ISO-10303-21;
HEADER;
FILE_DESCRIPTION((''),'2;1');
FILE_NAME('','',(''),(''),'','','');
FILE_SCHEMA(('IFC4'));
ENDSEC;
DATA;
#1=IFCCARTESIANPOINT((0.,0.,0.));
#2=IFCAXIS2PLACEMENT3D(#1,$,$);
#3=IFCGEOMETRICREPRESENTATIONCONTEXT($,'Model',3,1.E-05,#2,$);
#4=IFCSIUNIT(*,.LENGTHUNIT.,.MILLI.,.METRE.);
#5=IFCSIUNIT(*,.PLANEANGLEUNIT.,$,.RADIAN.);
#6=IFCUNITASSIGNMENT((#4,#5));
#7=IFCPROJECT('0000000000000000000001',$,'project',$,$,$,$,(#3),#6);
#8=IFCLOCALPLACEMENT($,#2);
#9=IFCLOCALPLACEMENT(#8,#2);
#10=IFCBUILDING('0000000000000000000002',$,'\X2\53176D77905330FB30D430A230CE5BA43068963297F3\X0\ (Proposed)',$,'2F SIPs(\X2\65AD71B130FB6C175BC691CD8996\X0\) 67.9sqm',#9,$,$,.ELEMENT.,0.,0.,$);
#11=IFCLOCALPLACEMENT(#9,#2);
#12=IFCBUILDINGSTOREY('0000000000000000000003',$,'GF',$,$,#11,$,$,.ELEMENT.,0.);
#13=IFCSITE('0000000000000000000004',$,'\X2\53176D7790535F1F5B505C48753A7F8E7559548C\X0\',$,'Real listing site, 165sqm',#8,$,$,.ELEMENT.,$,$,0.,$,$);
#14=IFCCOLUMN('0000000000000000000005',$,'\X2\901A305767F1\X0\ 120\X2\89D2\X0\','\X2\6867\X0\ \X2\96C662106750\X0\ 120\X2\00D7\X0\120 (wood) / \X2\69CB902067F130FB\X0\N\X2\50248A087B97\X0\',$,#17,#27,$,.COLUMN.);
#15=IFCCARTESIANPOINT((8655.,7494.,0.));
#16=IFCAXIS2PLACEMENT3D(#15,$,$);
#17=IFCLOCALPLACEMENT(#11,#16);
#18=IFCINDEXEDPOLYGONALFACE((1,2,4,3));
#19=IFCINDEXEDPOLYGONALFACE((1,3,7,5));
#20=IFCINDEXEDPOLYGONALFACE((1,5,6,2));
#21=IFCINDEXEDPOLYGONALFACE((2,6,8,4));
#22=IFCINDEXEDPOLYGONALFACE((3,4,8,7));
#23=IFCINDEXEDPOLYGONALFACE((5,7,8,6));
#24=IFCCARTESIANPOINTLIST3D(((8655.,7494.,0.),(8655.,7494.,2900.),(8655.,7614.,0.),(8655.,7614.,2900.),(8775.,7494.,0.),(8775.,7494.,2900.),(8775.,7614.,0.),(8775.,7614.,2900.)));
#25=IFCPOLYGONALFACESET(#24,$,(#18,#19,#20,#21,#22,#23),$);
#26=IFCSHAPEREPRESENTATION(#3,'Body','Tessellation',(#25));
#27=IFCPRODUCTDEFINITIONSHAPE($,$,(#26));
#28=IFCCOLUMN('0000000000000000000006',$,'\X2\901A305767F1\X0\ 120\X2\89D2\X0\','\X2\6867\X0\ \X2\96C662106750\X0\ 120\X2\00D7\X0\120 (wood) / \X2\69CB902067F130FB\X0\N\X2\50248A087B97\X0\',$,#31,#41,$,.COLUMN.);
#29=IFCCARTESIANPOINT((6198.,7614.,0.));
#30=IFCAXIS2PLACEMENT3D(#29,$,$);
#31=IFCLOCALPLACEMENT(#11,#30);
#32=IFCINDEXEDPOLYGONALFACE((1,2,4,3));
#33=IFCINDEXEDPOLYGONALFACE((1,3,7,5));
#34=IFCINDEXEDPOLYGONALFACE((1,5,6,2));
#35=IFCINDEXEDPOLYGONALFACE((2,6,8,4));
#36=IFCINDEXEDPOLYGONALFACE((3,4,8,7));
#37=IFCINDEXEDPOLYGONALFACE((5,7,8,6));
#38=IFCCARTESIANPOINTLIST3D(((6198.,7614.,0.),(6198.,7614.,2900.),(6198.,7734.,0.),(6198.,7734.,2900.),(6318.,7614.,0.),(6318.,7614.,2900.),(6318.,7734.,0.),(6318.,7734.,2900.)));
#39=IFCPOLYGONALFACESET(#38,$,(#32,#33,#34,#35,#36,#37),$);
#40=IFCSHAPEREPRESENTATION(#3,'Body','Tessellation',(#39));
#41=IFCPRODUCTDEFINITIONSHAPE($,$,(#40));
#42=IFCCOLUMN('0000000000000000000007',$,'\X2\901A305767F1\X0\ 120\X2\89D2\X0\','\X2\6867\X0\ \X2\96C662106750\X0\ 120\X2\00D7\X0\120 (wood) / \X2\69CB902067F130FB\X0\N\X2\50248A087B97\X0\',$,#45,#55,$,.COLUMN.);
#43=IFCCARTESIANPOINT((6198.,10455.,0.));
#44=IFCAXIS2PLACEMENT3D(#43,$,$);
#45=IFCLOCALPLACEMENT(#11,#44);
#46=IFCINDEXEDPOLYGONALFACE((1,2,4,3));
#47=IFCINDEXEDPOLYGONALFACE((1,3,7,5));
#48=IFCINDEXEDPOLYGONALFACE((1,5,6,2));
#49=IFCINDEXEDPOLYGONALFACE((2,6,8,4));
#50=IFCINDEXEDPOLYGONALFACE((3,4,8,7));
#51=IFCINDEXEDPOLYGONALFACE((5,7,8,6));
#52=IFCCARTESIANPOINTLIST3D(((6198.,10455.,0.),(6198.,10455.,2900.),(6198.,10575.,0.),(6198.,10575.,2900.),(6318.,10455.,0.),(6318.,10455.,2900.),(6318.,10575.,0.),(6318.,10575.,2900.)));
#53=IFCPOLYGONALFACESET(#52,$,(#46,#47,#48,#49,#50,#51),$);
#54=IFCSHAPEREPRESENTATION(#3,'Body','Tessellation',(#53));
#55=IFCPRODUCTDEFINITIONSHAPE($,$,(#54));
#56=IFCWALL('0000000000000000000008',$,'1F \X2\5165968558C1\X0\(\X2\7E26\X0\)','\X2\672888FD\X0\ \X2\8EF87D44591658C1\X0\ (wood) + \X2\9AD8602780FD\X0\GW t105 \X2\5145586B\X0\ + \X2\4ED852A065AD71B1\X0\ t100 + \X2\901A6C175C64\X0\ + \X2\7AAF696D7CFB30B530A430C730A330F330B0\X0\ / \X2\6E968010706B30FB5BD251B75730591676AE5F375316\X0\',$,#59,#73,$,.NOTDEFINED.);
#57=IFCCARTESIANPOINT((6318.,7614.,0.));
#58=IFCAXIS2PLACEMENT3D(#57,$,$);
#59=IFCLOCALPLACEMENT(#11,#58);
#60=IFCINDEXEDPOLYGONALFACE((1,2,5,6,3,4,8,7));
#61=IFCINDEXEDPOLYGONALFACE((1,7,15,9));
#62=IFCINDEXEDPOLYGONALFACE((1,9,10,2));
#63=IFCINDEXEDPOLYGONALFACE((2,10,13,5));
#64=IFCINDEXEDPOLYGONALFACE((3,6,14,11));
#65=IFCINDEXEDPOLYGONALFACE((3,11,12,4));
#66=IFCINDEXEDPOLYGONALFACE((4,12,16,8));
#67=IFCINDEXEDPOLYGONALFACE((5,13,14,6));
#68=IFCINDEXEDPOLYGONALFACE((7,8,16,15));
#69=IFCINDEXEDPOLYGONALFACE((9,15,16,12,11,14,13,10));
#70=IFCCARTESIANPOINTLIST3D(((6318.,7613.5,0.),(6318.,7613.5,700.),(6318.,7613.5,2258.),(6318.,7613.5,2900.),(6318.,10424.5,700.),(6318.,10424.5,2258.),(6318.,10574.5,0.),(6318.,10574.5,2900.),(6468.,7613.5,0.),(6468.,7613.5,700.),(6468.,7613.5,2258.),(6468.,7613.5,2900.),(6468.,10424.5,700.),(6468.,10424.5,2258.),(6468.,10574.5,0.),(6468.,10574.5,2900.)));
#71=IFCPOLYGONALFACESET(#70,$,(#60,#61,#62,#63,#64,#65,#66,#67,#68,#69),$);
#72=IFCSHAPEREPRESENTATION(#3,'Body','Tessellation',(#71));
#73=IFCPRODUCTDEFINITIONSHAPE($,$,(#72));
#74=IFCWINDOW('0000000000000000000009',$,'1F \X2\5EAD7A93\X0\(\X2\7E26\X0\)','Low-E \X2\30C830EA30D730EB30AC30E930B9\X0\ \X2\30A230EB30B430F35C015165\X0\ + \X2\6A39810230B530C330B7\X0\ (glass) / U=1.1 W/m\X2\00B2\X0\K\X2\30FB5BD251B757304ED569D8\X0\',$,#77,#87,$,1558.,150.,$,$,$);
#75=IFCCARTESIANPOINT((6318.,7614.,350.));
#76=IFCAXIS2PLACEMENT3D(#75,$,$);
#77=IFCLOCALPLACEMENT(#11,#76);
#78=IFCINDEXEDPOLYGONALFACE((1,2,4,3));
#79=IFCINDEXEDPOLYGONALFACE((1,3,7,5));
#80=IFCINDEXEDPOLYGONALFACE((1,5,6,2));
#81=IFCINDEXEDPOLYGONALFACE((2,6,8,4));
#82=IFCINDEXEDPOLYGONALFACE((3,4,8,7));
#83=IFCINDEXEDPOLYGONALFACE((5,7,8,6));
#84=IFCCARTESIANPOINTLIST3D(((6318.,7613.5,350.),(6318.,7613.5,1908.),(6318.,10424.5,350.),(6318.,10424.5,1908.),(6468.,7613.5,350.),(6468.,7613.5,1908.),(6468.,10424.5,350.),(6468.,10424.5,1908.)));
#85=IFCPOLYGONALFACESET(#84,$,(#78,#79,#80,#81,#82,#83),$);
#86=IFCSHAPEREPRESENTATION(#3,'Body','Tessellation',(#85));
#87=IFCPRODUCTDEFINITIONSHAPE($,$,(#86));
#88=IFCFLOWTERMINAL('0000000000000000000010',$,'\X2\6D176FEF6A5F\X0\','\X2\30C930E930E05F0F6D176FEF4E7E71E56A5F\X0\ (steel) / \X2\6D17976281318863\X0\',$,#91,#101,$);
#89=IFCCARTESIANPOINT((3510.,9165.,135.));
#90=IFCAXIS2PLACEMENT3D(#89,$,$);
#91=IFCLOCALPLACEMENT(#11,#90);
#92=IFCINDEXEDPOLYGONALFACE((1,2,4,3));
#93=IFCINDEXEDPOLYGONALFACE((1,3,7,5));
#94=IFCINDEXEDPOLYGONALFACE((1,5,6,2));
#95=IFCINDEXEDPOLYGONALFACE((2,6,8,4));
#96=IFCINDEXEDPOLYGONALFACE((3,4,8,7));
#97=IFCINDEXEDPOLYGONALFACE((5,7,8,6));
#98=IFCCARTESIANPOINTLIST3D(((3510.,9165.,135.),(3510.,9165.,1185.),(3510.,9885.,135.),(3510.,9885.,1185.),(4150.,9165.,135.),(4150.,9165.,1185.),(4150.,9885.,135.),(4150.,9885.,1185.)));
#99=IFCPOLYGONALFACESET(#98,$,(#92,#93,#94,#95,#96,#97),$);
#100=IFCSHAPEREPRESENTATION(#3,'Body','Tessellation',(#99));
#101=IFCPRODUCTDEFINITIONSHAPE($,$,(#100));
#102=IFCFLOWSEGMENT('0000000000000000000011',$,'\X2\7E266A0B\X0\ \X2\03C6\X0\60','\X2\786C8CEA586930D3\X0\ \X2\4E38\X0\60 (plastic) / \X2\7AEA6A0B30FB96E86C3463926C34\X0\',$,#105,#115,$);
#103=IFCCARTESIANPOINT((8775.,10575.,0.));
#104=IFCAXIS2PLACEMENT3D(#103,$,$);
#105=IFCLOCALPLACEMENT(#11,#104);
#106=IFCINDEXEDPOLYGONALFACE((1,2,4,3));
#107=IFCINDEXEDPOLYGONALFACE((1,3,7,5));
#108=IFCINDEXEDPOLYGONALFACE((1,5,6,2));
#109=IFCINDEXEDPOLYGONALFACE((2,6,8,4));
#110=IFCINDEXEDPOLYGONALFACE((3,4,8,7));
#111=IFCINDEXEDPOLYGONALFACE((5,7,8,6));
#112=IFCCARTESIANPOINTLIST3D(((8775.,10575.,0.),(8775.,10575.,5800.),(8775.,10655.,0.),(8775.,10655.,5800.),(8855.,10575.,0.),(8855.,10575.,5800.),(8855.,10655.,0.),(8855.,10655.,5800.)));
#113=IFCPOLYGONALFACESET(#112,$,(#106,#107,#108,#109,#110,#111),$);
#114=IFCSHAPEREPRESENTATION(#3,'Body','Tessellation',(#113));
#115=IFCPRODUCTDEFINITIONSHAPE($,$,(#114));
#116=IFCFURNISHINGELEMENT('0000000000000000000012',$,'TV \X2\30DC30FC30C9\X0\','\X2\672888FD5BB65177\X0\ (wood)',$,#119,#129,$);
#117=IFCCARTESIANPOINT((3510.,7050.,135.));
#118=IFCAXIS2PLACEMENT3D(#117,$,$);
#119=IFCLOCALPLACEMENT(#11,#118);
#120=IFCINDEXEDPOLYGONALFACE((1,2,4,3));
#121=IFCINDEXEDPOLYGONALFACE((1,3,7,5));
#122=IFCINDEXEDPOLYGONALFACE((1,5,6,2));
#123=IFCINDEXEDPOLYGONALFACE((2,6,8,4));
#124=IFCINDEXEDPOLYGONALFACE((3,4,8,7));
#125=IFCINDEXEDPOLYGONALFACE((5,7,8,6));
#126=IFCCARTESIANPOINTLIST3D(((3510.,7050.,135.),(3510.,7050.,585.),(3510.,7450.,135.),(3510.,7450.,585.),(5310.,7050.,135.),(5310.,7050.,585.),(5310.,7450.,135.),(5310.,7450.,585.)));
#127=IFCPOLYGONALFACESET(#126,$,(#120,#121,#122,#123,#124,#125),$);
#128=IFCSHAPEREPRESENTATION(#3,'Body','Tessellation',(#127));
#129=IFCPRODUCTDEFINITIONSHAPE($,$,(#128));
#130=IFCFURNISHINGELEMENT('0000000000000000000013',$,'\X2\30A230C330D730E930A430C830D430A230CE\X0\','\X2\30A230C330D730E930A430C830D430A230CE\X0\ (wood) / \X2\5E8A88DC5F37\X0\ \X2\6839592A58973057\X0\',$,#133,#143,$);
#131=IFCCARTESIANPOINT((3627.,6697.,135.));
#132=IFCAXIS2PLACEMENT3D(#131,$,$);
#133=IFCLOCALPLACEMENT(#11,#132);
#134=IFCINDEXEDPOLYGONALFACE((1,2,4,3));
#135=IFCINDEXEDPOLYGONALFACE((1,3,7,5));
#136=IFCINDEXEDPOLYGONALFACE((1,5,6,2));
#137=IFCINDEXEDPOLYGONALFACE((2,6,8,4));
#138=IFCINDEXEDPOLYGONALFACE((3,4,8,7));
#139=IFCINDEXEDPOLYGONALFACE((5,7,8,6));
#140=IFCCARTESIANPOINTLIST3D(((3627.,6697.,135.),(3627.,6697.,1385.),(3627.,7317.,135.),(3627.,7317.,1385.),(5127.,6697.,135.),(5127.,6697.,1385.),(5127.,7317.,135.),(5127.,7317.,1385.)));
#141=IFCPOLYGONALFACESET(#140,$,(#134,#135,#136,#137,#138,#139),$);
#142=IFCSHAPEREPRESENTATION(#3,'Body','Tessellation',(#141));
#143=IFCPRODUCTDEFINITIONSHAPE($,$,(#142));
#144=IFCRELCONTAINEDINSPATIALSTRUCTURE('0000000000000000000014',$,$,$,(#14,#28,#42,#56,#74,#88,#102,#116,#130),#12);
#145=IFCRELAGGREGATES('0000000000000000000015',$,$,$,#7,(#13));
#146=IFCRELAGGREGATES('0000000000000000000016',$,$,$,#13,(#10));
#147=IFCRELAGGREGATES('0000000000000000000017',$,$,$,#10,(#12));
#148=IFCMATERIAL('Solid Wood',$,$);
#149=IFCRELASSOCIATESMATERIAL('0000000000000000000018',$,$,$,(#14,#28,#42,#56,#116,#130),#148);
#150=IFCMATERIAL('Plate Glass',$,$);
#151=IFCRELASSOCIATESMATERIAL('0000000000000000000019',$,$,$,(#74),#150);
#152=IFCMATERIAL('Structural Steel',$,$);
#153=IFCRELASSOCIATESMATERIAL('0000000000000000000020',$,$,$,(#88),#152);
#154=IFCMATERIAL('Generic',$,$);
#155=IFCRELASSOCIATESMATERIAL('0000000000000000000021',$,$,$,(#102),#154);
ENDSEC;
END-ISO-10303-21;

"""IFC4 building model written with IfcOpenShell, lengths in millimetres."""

from ifc_helpers import new_model, si_unit, frame, frame_2d, origin, place, context, project, spatial, rectangle, extrude, material, element, fill, save


model = new_model("IFC4")

# Units and contexts
model_context = context("Model", 3, precision=1e-05, world=origin())
ifc_project = project(units=[si_unit("LENGTHUNIT", "METRE", prefix="MILLI"), si_unit("PLANEANGLEUNIT", "RADIAN")], contexts=[model_context])

# Site, building, storey
site_placement = place(None, origin())
site = spatial("IfcSite", under=ifc_project, at=site_placement, Name="北海道弟子屈町美留和", ObjectType="Real listing site, 165sqm", CompositionType="ELEMENT", RefElevation=0.0)
building_placement = place(site_placement, origin())
building = spatial("IfcBuilding", under=site, at=building_placement, Name="北海道・ピアノ室と防音 (Proposed)", ObjectType="2F SIPs(断熱・気密重視) 67.9sqm", CompositionType="ELEMENT", ElevationOfRefHeight=0.0, ElevationOfTerrain=0.0)
storey_placement = place(building_placement, origin())
storey = spatial("IfcBuildingStorey", under=building, at=storey_placement, Name="GF", CompositionType="ELEMENT", Elevation=0.0)

# Columns
ifc_material_1 = material(Name="Solid Wood")
column_1_placement = place(storey_placement, frame((8655.0, 7494.0, 0.0)))
element("IfcColumn", 1, at=column_1_placement, inside=storey, material=ifc_material_1, Name="通し柱 120角", Description="桧 集成材 120×120 (wood) / 構造柱・N値計算", PredefinedType="COLUMN", context=model_context, shape_type="SweptSolid", body=[
    extrude(rectangle(XDim=120.0, YDim=120.0, at=frame_2d((60.0, 60.0))), frame((8655.0, 7494.0, 0.0)), (0.0, 0.0, 1.0), 2900.0),
])
column_2_placement = place(storey_placement, frame((6198.0, 7614.0, 0.0)))
element("IfcColumn", 2, at=column_2_placement, inside=storey, material=ifc_material_1, Name="通し柱 120角", Description="桧 集成材 120×120 (wood) / 構造柱・N値計算", PredefinedType="COLUMN", context=model_context, shape_type="SweptSolid", body=[
    extrude(rectangle(XDim=120.0, YDim=120.0, at=frame_2d((60.0, 60.0))), frame((6198.0, 7614.0, 0.0)), (0.0, 0.0, 1.0), 2900.0),
])
column_3_placement = place(storey_placement, frame((6198.0, 10455.0, 0.0)))
element("IfcColumn", 3, at=column_3_placement, inside=storey, material=ifc_material_1, Name="通し柱 120角", Description="桧 集成材 120×120 (wood) / 構造柱・N値計算", PredefinedType="COLUMN", context=model_context, shape_type="SweptSolid", body=[
    extrude(rectangle(XDim=120.0, YDim=120.0, at=frame_2d((60.0, 60.0))), frame((6198.0, 10455.0, 0.0)), (0.0, 0.0, 1.0), 2900.0),
])

# Wall, opening, window
wall_1_placement = place(storey_placement, frame((6318.0, 7614.0, 0.0)))
wall_1 = element("IfcWall", 4, at=wall_1_placement, inside=storey, material=ifc_material_1, Name="1F 入隅壁(縦)", Description="木製 軸組外壁 (wood) + 高性能GW t105 充填 + 付加断熱 t100 + 通気層 + 窯業系サイディング / 準耐火・寒冷地外皮強化", PredefinedType="NOTDEFINED", context=model_context, shape_type="SweptSolid", body=[
    extrude(rectangle(XDim=150.0, YDim=2961.0, at=frame_2d((75.0, 1480.0))), frame((6318.0, 7614.0, 0.0)), (0.0, 0.0, 1.0), 2900.0),
])
opening_placement = place(storey_placement, frame((6318.0, 7614.0, 350.0)))
opening = element("IfcOpeningElement", 5, at=opening_placement, cuts=wall_1, PredefinedType="NOTDEFINED", context=model_context, shape_type="SweptSolid", body=[
    extrude(rectangle(XDim=150.0, YDim=2811.0, at=frame_2d((75.0, 1405.0))), frame((6318.0, 7614.0, 350.0)), (0.0, 0.0, 1.0), 1558.0),
])
ifc_material_2 = material(Name="Plate Glass")
window_placement = place(storey_placement, frame((6318.0, 7614.0, 350.0)))
window = element("IfcWindow", 6, at=window_placement, inside=storey, material=ifc_material_2, Name="1F 庭窓(縦)", Description="Low-E トリプルガラス アルゴン封入 + 樹脂サッシ (glass) / U=1.1 W/m²K・寒冷地仕様", OverallHeight=1558.0, OverallWidth=150.0, context=model_context, shape_type="SweptSolid", body=[
    extrude(rectangle(XDim=150.0, YDim=2811.0, at=frame_2d((75.0, 1405.0))), frame((6318.0, 7614.0, 350.0)), (0.0, 0.0, 1.0), 1558.0),
])
fill(opening, window)

# Flow terminal
ifc_material_3 = material(Name="Structural Steel")
flow_terminal_placement = place(storey_placement, frame((3510.0, 9165.0, 135.0)))
element("IfcFlowTerminal", 7, at=flow_terminal_placement, inside=storey, material=ifc_material_3, Name="洗濯機", Description="ドラム式洗濯乾燥機 (steel) / 洗面脱衣", context=model_context, shape_type="SweptSolid", body=[
    extrude(rectangle(XDim=640.0, YDim=720.0, at=frame_2d((320.0, 360.0))), frame((3510.0, 9165.0, 135.0)), (0.0, 0.0, 1.0), 1050.0),
])

# Flow segment
ifc_material_4 = material(Name="Generic")
flow_segment_placement = place(storey_placement, frame((8775.0, 10575.0, 0.0)))
element("IfcFlowSegment", 8, at=flow_segment_placement, inside=storey, material=ifc_material_4, Name="縦樋 φ60", Description="硬質塩ビ 丸60 (plastic) / 竪樋・雨水排水", context=model_context, shape_type="SweptSolid", body=[
    extrude(rectangle(XDim=80.0, YDim=80.0, at=frame_2d((40.0, 40.0))), frame((8775.0, 10575.0, 0.0)), (0.0, 0.0, 1.0), 5800.0),
])

# Furnishing elements
furnishing_1_placement = place(storey_placement, frame((3510.0, 7050.0, 135.0)))
element("IfcFurnishingElement", 9, at=furnishing_1_placement, inside=storey, material=ifc_material_1, Name="TV ボード", Description="木製家具 (wood)", context=model_context, shape_type="SweptSolid", body=[
    extrude(rectangle(XDim=1800.0, YDim=400.0, at=frame_2d((900.0, 200.0))), frame((3510.0, 7050.0, 135.0)), (0.0, 0.0, 1.0), 450.0),
])
furnishing_2_placement = place(storey_placement, frame((3627.0, 6697.0, 135.0)))
element("IfcFurnishingElement", 10, at=furnishing_2_placement, inside=storey, material=ifc_material_1, Name="アップライトピアノ", Description="アップライトピアノ (wood) / 床補強 根太増し", context=model_context, shape_type="SweptSolid", body=[
    extrude(rectangle(XDim=1500.0, YDim=620.0, at=frame_2d((750.0, 310.0))), frame((3627.0, 6697.0, 135.0)), (0.0, 0.0, 1.0), 1250.0),
])

save(model, "model.ifc")
